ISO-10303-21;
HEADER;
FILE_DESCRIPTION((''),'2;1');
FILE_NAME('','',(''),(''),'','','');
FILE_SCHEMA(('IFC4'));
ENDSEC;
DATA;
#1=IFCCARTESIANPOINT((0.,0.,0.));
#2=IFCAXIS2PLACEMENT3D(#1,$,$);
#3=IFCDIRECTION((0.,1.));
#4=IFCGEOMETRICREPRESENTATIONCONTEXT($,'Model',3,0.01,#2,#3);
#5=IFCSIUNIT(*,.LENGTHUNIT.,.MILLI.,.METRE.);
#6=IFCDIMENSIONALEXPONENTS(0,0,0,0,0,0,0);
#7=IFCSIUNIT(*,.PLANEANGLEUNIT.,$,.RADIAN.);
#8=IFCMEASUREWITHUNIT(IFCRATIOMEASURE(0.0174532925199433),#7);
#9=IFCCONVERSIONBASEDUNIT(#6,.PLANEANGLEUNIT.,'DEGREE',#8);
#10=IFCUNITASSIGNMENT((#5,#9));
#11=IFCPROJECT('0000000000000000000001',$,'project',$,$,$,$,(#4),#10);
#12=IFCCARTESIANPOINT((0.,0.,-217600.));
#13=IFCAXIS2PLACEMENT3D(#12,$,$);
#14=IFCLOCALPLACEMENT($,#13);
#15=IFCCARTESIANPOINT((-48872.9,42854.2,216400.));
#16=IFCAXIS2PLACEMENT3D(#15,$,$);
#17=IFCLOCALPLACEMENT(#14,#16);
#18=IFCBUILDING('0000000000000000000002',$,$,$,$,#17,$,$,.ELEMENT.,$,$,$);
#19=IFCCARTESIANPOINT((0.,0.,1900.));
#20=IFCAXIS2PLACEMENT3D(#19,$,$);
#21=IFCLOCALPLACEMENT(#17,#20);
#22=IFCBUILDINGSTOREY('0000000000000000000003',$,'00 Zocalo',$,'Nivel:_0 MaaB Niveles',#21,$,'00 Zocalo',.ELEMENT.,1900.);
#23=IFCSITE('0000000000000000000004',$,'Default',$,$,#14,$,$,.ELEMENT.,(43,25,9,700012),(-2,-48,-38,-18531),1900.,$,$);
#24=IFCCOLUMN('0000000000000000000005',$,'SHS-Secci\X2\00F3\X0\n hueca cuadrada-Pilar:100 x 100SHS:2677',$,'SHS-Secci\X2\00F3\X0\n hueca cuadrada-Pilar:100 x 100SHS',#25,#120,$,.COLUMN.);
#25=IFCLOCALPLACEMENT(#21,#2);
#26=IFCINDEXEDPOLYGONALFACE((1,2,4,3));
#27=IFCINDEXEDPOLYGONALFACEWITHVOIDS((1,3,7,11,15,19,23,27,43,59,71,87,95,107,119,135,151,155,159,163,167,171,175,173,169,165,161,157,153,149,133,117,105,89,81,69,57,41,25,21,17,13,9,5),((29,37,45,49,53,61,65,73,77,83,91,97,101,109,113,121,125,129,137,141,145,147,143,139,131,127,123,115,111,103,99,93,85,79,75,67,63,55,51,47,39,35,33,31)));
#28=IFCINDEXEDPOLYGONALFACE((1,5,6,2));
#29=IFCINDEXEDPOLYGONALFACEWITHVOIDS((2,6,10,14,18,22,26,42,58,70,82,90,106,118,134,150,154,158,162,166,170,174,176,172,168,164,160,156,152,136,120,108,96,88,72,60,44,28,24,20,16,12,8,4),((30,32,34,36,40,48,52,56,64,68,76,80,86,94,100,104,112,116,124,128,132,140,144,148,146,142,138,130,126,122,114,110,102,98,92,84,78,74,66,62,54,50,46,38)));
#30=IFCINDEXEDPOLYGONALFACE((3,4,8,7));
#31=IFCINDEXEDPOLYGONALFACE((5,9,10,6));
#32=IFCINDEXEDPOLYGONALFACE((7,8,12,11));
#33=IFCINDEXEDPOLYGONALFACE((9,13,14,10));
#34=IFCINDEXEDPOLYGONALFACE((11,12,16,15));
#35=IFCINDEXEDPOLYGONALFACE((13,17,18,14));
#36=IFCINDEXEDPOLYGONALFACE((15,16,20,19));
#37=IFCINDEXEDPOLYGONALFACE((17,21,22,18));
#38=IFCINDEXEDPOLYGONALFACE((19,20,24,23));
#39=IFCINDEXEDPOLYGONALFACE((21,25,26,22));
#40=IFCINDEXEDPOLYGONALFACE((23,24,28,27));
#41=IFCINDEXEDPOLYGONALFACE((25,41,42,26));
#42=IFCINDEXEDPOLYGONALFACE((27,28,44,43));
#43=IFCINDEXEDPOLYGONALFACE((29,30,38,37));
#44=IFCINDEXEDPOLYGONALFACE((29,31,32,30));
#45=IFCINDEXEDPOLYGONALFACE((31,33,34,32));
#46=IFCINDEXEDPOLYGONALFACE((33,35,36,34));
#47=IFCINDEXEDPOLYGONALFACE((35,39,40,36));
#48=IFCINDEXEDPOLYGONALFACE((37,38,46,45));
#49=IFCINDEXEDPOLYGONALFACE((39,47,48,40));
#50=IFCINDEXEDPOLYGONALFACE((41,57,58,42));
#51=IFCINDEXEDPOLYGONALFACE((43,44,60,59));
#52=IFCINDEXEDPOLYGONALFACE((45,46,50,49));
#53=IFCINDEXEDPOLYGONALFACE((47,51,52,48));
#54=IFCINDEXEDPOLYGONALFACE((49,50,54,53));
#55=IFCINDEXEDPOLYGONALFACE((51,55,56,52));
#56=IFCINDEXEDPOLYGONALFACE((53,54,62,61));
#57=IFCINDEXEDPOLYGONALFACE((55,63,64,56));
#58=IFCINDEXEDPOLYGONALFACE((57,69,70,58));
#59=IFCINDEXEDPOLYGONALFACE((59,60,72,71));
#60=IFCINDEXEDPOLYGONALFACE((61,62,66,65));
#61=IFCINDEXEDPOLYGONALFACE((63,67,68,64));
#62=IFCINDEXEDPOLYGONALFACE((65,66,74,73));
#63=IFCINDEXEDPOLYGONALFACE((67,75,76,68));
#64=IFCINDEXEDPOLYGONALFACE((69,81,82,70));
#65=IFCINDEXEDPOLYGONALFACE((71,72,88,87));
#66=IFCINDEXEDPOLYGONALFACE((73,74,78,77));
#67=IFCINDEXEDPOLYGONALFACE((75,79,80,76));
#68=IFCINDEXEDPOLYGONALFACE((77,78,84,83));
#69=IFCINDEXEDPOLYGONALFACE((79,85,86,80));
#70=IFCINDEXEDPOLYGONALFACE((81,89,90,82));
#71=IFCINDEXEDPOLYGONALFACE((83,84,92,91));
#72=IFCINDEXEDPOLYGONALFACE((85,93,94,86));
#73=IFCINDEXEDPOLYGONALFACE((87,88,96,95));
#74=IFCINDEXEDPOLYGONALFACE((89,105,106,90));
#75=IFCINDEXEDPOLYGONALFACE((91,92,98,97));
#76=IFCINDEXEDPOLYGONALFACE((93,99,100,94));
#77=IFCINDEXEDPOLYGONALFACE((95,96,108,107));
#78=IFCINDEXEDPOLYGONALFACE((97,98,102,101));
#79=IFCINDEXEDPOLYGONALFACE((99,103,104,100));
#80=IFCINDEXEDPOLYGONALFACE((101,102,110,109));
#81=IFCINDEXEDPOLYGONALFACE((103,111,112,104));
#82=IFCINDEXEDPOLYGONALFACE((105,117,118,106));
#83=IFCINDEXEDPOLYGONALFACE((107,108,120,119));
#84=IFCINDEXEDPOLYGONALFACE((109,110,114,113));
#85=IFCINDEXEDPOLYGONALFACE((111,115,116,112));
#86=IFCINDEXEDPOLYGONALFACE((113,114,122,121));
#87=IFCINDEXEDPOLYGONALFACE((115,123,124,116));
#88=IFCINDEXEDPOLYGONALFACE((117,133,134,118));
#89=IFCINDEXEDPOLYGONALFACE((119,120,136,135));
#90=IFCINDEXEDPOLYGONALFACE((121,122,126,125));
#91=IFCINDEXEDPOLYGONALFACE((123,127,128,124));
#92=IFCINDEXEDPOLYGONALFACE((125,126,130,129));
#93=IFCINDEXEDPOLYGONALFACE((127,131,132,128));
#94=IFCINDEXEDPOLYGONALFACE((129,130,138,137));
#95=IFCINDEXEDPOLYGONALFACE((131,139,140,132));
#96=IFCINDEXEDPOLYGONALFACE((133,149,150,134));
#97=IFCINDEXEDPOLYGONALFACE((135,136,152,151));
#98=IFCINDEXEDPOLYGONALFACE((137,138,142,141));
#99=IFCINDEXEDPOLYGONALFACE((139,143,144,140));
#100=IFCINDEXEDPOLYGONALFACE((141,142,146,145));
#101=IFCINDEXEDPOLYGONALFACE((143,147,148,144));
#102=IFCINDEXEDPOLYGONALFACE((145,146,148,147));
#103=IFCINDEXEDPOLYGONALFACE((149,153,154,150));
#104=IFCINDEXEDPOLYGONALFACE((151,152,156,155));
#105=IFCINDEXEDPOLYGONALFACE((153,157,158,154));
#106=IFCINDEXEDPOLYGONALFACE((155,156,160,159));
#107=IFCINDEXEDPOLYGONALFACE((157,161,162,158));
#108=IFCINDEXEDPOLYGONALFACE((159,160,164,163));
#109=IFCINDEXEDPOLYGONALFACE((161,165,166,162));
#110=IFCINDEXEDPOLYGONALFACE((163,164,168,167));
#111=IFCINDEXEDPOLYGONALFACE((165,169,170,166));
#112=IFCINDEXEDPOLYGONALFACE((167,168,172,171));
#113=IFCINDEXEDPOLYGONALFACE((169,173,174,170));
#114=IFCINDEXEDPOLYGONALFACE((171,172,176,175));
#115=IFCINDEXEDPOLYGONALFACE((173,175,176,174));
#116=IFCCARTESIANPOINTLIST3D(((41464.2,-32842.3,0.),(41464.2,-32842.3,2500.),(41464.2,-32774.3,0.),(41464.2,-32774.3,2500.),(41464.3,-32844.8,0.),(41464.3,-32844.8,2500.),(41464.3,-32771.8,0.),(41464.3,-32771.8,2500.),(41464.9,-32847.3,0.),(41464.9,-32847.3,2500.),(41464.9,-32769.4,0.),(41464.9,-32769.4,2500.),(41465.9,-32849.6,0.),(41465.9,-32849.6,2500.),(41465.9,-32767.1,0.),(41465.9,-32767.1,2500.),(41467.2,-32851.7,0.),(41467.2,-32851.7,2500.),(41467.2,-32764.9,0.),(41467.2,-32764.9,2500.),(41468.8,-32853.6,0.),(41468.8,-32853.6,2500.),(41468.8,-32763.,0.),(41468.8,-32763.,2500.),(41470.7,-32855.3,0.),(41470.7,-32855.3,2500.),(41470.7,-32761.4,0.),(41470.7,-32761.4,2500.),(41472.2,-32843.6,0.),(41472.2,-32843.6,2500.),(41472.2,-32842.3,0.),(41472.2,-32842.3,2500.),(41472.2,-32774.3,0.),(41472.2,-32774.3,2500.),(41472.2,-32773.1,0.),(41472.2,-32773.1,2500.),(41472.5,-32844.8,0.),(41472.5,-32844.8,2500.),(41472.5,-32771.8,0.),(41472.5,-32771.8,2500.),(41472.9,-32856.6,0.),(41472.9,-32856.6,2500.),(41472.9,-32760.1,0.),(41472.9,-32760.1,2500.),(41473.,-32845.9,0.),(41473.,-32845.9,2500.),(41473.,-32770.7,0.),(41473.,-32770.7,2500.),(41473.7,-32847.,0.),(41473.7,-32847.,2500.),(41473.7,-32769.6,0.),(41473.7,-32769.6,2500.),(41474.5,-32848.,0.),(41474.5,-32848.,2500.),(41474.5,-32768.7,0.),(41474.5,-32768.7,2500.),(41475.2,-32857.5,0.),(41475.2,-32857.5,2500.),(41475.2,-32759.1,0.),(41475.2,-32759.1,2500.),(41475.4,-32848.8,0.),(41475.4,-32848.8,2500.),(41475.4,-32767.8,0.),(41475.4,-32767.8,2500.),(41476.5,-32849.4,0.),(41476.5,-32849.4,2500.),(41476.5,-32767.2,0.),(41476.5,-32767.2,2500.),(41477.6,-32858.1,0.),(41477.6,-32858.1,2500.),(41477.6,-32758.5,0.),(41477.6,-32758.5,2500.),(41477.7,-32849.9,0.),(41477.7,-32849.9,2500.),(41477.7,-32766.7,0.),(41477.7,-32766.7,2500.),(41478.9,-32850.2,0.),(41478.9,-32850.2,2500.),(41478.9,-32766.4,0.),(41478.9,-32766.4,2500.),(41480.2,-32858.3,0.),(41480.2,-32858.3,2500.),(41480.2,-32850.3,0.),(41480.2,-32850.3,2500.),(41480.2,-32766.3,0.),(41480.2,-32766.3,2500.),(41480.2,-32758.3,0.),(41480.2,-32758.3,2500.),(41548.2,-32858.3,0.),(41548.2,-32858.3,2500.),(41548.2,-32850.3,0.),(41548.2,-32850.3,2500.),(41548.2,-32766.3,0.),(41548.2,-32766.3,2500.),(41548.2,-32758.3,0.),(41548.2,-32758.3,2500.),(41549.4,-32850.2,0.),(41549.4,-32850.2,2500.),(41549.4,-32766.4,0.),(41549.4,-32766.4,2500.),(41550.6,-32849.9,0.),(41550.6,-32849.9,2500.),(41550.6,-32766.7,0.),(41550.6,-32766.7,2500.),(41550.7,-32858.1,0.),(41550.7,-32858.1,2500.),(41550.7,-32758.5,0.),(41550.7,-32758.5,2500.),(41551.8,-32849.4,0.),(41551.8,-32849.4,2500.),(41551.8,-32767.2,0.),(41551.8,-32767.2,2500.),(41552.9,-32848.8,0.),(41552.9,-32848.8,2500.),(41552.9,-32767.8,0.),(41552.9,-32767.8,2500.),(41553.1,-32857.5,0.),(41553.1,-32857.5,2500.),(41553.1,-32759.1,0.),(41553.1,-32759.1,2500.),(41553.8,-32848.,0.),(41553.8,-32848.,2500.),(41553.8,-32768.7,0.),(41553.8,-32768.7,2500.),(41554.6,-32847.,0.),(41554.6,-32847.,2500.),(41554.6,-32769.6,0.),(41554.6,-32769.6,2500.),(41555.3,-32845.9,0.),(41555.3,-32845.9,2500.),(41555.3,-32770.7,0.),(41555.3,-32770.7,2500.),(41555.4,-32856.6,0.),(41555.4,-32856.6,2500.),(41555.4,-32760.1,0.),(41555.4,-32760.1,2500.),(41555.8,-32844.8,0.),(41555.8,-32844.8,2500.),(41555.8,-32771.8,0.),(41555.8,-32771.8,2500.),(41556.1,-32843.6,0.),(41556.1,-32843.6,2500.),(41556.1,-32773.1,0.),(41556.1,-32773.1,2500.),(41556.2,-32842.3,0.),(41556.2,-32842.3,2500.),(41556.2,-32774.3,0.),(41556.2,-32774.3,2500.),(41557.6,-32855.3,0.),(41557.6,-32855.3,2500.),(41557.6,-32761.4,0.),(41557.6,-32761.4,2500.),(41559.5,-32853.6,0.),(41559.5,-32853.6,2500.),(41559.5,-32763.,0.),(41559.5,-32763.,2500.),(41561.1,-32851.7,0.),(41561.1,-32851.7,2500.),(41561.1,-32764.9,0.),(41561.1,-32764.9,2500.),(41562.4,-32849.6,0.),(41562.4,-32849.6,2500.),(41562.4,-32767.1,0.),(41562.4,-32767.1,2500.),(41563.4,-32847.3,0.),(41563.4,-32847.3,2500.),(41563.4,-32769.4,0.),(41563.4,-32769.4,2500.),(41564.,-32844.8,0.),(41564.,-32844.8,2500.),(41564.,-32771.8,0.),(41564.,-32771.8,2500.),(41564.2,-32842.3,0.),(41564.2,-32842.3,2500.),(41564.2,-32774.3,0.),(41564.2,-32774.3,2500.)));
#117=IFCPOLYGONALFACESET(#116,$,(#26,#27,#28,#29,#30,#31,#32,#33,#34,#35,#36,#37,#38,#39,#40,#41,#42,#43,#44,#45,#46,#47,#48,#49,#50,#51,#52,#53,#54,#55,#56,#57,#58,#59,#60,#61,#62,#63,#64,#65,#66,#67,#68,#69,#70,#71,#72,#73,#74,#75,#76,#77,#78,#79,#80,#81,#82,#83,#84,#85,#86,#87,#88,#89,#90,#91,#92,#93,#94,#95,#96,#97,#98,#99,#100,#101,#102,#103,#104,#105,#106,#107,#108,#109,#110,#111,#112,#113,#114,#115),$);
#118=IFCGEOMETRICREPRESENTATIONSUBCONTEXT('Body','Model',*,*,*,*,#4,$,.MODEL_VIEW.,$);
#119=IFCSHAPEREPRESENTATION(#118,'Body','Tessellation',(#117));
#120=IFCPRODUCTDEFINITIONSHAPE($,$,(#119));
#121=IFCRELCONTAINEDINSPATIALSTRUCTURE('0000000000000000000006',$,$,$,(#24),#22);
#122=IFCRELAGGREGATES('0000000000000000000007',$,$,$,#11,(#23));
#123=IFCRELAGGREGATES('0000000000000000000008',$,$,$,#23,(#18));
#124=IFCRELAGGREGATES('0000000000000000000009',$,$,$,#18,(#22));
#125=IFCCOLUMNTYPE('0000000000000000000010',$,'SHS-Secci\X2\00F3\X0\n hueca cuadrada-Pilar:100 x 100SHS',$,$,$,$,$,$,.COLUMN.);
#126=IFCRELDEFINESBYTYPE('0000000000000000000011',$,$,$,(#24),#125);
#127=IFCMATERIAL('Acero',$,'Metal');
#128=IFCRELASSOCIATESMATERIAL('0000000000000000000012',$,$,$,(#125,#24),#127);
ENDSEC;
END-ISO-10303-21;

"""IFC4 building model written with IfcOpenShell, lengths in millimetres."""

from ifc_helpers import new_model, entity, si_unit, converted_unit, direction, frame, origin, place, context, subcontext, project, spatial, indexed_curve, outline, extrude, source, transform, mapped, material, type_object, type_shapes, element, save


model = new_model("IFC4")

# Units and contexts
model_context = context("Model", 3, precision=0.01, world=origin(), true_north=direction((0.0, 1.0)))
body_context = subcontext(model_context, "Body", "Model", "MODEL_VIEW")
ifc_project = project(units=[si_unit("LENGTHUNIT", "METRE", prefix="MILLI"), converted_unit("PLANEANGLEUNIT", "DEGREE", entity("IfcRatioMeasure", 0.0174532925199433), si_unit("PLANEANGLEUNIT", "RADIAN"), dimensions=[0, 0, 0, 0, 0, 0, 0])], contexts=[model_context])

# Site, building, storey
site_placement = place(None, frame((0.0, 0.0, -217600.0)))
site = spatial("IfcSite", under=ifc_project, at=site_placement, Name="Default", CompositionType="ELEMENT", RefLatitude=(43, 25, 9, 700012), RefLongitude=(-2, -48, -38, -18531), RefElevation=1900.0)
building_placement = place(site_placement, frame((-48872.9, 42854.2, 216400.0)))
building = spatial("IfcBuilding", under=site, at=building_placement, CompositionType="ELEMENT")
storey_placement = place(building_placement, frame((0.0, 0.0, 1900.0)))
storey = spatial("IfcBuildingStorey", under=building, at=storey_placement, Name="00 Zocalo", ObjectType="Nivel:_0 MaaB Niveles", LongName="00 Zocalo", CompositionType="ELEMENT", Elevation=1900.0)

# Column
ifc_material = material(Name="Acero", Category="Metal")
column_type_1 = type_object("IfcColumnType", Name="SHS-Sección hueca cuadrada-Pilar:100 x 100SHS", PredefinedType="COLUMN", material=ifc_material)
shared_shape_1 = source(origin(), body_context, "Body", "SweptSolid", [
    extrude(outline(indexed_curve([(34.0, -50.0), (36.5, -49.8), (38.9, -49.2), (41.3, -48.3), (43.4, -46.9), (45.3, -45.3), (46.9, -43.4), (48.3, -41.3), (49.2, -38.9), (49.8, -36.5), (50.0, -34.0), (50.0, 34.0), (49.8, 36.5), (49.2, 38.9), (48.3, 41.3), (46.9, 43.4), (45.3, 45.3), (43.4, 46.9), (41.3, 48.3), (38.9, 49.2), (36.5, 49.8), (34.0, 50.0), (-34.0, 50.0), (-36.5, 49.8), (-38.9, 49.2), (-41.3, 48.3), (-43.4, 46.9), (-45.3, 45.3), (-46.9, 43.4), (-48.3, 41.3), (-49.2, 38.9), (-49.8, 36.5), (-50.0, 34.0), (-50.0, -34.0), (-49.8, -36.5), (-49.2, -38.9), (-48.3, -41.3), (-46.9, -43.4), (-45.3, -45.3), (-43.4, -46.9), (-41.3, -48.3), (-38.9, -49.2), (-36.5, -49.8), (-34.0, -50.0), (34.0, -50.0)], self_intersect=False), holes=[indexed_curve([(34.0, -42.0), (-34.0, -42.0), (-35.3, -41.9), (-36.5, -41.6), (-37.6, -41.1), (-38.7, -40.5), (-39.7, -39.7), (-40.5, -38.7), (-41.1, -37.6), (-41.6, -36.5), (-41.9, -35.3), (-42.0, -34.0), (-42.0, 34.0), (-41.9, 35.3), (-41.6, 36.5), (-41.1, 37.6), (-40.5, 38.7), (-39.7, 39.7), (-38.7, 40.5), (-37.6, 41.1), (-36.5, 41.6), (-35.3, 41.9), (-34.0, 42.0), (34.0, 42.0), (35.3, 41.9), (36.5, 41.6), (37.6, 41.1), (38.7, 40.5), (39.7, 39.7), (40.5, 38.7), (41.1, 37.6), (41.6, 36.5), (41.9, 35.3), (42.0, 34.0), (42.0, -34.0), (41.9, -35.3), (41.6, -36.5), (41.1, -37.6), (40.5, -38.7), (39.7, -39.7), (38.7, -40.5), (37.6, -41.1), (36.5, -41.6), (35.3, -41.9), (34.0, -42.0)], self_intersect=False)]), frame((0.0, 0.0, 1900.0)), (0.0, 0.0, 1.0), 2500.0),
])
type_shapes(column_type_1, [shared_shape_1])
column_1_placement = place(storey_placement, frame((41514.2, -32808.3, -1900.0), z_axis=(0.0, 0.0, 1.0), x_axis=(0.0, -1.0, 0.0)))
element("IfcColumn", 1, at=column_1_placement, inside=storey, type_object=column_type_1, material=ifc_material, Name="SHS-Sección hueca cuadrada-Pilar:100 x 100SHS:2677", ObjectType="SHS-Sección hueca cuadrada-Pilar:100 x 100SHS", PredefinedType="COLUMN", context=body_context, shape_type="MappedRepresentation", body=[
    mapped(shared_shape_1, transform((0.0, 0.0, 0.0), scale=1.0)),
])

save(model, "model.ifc")
